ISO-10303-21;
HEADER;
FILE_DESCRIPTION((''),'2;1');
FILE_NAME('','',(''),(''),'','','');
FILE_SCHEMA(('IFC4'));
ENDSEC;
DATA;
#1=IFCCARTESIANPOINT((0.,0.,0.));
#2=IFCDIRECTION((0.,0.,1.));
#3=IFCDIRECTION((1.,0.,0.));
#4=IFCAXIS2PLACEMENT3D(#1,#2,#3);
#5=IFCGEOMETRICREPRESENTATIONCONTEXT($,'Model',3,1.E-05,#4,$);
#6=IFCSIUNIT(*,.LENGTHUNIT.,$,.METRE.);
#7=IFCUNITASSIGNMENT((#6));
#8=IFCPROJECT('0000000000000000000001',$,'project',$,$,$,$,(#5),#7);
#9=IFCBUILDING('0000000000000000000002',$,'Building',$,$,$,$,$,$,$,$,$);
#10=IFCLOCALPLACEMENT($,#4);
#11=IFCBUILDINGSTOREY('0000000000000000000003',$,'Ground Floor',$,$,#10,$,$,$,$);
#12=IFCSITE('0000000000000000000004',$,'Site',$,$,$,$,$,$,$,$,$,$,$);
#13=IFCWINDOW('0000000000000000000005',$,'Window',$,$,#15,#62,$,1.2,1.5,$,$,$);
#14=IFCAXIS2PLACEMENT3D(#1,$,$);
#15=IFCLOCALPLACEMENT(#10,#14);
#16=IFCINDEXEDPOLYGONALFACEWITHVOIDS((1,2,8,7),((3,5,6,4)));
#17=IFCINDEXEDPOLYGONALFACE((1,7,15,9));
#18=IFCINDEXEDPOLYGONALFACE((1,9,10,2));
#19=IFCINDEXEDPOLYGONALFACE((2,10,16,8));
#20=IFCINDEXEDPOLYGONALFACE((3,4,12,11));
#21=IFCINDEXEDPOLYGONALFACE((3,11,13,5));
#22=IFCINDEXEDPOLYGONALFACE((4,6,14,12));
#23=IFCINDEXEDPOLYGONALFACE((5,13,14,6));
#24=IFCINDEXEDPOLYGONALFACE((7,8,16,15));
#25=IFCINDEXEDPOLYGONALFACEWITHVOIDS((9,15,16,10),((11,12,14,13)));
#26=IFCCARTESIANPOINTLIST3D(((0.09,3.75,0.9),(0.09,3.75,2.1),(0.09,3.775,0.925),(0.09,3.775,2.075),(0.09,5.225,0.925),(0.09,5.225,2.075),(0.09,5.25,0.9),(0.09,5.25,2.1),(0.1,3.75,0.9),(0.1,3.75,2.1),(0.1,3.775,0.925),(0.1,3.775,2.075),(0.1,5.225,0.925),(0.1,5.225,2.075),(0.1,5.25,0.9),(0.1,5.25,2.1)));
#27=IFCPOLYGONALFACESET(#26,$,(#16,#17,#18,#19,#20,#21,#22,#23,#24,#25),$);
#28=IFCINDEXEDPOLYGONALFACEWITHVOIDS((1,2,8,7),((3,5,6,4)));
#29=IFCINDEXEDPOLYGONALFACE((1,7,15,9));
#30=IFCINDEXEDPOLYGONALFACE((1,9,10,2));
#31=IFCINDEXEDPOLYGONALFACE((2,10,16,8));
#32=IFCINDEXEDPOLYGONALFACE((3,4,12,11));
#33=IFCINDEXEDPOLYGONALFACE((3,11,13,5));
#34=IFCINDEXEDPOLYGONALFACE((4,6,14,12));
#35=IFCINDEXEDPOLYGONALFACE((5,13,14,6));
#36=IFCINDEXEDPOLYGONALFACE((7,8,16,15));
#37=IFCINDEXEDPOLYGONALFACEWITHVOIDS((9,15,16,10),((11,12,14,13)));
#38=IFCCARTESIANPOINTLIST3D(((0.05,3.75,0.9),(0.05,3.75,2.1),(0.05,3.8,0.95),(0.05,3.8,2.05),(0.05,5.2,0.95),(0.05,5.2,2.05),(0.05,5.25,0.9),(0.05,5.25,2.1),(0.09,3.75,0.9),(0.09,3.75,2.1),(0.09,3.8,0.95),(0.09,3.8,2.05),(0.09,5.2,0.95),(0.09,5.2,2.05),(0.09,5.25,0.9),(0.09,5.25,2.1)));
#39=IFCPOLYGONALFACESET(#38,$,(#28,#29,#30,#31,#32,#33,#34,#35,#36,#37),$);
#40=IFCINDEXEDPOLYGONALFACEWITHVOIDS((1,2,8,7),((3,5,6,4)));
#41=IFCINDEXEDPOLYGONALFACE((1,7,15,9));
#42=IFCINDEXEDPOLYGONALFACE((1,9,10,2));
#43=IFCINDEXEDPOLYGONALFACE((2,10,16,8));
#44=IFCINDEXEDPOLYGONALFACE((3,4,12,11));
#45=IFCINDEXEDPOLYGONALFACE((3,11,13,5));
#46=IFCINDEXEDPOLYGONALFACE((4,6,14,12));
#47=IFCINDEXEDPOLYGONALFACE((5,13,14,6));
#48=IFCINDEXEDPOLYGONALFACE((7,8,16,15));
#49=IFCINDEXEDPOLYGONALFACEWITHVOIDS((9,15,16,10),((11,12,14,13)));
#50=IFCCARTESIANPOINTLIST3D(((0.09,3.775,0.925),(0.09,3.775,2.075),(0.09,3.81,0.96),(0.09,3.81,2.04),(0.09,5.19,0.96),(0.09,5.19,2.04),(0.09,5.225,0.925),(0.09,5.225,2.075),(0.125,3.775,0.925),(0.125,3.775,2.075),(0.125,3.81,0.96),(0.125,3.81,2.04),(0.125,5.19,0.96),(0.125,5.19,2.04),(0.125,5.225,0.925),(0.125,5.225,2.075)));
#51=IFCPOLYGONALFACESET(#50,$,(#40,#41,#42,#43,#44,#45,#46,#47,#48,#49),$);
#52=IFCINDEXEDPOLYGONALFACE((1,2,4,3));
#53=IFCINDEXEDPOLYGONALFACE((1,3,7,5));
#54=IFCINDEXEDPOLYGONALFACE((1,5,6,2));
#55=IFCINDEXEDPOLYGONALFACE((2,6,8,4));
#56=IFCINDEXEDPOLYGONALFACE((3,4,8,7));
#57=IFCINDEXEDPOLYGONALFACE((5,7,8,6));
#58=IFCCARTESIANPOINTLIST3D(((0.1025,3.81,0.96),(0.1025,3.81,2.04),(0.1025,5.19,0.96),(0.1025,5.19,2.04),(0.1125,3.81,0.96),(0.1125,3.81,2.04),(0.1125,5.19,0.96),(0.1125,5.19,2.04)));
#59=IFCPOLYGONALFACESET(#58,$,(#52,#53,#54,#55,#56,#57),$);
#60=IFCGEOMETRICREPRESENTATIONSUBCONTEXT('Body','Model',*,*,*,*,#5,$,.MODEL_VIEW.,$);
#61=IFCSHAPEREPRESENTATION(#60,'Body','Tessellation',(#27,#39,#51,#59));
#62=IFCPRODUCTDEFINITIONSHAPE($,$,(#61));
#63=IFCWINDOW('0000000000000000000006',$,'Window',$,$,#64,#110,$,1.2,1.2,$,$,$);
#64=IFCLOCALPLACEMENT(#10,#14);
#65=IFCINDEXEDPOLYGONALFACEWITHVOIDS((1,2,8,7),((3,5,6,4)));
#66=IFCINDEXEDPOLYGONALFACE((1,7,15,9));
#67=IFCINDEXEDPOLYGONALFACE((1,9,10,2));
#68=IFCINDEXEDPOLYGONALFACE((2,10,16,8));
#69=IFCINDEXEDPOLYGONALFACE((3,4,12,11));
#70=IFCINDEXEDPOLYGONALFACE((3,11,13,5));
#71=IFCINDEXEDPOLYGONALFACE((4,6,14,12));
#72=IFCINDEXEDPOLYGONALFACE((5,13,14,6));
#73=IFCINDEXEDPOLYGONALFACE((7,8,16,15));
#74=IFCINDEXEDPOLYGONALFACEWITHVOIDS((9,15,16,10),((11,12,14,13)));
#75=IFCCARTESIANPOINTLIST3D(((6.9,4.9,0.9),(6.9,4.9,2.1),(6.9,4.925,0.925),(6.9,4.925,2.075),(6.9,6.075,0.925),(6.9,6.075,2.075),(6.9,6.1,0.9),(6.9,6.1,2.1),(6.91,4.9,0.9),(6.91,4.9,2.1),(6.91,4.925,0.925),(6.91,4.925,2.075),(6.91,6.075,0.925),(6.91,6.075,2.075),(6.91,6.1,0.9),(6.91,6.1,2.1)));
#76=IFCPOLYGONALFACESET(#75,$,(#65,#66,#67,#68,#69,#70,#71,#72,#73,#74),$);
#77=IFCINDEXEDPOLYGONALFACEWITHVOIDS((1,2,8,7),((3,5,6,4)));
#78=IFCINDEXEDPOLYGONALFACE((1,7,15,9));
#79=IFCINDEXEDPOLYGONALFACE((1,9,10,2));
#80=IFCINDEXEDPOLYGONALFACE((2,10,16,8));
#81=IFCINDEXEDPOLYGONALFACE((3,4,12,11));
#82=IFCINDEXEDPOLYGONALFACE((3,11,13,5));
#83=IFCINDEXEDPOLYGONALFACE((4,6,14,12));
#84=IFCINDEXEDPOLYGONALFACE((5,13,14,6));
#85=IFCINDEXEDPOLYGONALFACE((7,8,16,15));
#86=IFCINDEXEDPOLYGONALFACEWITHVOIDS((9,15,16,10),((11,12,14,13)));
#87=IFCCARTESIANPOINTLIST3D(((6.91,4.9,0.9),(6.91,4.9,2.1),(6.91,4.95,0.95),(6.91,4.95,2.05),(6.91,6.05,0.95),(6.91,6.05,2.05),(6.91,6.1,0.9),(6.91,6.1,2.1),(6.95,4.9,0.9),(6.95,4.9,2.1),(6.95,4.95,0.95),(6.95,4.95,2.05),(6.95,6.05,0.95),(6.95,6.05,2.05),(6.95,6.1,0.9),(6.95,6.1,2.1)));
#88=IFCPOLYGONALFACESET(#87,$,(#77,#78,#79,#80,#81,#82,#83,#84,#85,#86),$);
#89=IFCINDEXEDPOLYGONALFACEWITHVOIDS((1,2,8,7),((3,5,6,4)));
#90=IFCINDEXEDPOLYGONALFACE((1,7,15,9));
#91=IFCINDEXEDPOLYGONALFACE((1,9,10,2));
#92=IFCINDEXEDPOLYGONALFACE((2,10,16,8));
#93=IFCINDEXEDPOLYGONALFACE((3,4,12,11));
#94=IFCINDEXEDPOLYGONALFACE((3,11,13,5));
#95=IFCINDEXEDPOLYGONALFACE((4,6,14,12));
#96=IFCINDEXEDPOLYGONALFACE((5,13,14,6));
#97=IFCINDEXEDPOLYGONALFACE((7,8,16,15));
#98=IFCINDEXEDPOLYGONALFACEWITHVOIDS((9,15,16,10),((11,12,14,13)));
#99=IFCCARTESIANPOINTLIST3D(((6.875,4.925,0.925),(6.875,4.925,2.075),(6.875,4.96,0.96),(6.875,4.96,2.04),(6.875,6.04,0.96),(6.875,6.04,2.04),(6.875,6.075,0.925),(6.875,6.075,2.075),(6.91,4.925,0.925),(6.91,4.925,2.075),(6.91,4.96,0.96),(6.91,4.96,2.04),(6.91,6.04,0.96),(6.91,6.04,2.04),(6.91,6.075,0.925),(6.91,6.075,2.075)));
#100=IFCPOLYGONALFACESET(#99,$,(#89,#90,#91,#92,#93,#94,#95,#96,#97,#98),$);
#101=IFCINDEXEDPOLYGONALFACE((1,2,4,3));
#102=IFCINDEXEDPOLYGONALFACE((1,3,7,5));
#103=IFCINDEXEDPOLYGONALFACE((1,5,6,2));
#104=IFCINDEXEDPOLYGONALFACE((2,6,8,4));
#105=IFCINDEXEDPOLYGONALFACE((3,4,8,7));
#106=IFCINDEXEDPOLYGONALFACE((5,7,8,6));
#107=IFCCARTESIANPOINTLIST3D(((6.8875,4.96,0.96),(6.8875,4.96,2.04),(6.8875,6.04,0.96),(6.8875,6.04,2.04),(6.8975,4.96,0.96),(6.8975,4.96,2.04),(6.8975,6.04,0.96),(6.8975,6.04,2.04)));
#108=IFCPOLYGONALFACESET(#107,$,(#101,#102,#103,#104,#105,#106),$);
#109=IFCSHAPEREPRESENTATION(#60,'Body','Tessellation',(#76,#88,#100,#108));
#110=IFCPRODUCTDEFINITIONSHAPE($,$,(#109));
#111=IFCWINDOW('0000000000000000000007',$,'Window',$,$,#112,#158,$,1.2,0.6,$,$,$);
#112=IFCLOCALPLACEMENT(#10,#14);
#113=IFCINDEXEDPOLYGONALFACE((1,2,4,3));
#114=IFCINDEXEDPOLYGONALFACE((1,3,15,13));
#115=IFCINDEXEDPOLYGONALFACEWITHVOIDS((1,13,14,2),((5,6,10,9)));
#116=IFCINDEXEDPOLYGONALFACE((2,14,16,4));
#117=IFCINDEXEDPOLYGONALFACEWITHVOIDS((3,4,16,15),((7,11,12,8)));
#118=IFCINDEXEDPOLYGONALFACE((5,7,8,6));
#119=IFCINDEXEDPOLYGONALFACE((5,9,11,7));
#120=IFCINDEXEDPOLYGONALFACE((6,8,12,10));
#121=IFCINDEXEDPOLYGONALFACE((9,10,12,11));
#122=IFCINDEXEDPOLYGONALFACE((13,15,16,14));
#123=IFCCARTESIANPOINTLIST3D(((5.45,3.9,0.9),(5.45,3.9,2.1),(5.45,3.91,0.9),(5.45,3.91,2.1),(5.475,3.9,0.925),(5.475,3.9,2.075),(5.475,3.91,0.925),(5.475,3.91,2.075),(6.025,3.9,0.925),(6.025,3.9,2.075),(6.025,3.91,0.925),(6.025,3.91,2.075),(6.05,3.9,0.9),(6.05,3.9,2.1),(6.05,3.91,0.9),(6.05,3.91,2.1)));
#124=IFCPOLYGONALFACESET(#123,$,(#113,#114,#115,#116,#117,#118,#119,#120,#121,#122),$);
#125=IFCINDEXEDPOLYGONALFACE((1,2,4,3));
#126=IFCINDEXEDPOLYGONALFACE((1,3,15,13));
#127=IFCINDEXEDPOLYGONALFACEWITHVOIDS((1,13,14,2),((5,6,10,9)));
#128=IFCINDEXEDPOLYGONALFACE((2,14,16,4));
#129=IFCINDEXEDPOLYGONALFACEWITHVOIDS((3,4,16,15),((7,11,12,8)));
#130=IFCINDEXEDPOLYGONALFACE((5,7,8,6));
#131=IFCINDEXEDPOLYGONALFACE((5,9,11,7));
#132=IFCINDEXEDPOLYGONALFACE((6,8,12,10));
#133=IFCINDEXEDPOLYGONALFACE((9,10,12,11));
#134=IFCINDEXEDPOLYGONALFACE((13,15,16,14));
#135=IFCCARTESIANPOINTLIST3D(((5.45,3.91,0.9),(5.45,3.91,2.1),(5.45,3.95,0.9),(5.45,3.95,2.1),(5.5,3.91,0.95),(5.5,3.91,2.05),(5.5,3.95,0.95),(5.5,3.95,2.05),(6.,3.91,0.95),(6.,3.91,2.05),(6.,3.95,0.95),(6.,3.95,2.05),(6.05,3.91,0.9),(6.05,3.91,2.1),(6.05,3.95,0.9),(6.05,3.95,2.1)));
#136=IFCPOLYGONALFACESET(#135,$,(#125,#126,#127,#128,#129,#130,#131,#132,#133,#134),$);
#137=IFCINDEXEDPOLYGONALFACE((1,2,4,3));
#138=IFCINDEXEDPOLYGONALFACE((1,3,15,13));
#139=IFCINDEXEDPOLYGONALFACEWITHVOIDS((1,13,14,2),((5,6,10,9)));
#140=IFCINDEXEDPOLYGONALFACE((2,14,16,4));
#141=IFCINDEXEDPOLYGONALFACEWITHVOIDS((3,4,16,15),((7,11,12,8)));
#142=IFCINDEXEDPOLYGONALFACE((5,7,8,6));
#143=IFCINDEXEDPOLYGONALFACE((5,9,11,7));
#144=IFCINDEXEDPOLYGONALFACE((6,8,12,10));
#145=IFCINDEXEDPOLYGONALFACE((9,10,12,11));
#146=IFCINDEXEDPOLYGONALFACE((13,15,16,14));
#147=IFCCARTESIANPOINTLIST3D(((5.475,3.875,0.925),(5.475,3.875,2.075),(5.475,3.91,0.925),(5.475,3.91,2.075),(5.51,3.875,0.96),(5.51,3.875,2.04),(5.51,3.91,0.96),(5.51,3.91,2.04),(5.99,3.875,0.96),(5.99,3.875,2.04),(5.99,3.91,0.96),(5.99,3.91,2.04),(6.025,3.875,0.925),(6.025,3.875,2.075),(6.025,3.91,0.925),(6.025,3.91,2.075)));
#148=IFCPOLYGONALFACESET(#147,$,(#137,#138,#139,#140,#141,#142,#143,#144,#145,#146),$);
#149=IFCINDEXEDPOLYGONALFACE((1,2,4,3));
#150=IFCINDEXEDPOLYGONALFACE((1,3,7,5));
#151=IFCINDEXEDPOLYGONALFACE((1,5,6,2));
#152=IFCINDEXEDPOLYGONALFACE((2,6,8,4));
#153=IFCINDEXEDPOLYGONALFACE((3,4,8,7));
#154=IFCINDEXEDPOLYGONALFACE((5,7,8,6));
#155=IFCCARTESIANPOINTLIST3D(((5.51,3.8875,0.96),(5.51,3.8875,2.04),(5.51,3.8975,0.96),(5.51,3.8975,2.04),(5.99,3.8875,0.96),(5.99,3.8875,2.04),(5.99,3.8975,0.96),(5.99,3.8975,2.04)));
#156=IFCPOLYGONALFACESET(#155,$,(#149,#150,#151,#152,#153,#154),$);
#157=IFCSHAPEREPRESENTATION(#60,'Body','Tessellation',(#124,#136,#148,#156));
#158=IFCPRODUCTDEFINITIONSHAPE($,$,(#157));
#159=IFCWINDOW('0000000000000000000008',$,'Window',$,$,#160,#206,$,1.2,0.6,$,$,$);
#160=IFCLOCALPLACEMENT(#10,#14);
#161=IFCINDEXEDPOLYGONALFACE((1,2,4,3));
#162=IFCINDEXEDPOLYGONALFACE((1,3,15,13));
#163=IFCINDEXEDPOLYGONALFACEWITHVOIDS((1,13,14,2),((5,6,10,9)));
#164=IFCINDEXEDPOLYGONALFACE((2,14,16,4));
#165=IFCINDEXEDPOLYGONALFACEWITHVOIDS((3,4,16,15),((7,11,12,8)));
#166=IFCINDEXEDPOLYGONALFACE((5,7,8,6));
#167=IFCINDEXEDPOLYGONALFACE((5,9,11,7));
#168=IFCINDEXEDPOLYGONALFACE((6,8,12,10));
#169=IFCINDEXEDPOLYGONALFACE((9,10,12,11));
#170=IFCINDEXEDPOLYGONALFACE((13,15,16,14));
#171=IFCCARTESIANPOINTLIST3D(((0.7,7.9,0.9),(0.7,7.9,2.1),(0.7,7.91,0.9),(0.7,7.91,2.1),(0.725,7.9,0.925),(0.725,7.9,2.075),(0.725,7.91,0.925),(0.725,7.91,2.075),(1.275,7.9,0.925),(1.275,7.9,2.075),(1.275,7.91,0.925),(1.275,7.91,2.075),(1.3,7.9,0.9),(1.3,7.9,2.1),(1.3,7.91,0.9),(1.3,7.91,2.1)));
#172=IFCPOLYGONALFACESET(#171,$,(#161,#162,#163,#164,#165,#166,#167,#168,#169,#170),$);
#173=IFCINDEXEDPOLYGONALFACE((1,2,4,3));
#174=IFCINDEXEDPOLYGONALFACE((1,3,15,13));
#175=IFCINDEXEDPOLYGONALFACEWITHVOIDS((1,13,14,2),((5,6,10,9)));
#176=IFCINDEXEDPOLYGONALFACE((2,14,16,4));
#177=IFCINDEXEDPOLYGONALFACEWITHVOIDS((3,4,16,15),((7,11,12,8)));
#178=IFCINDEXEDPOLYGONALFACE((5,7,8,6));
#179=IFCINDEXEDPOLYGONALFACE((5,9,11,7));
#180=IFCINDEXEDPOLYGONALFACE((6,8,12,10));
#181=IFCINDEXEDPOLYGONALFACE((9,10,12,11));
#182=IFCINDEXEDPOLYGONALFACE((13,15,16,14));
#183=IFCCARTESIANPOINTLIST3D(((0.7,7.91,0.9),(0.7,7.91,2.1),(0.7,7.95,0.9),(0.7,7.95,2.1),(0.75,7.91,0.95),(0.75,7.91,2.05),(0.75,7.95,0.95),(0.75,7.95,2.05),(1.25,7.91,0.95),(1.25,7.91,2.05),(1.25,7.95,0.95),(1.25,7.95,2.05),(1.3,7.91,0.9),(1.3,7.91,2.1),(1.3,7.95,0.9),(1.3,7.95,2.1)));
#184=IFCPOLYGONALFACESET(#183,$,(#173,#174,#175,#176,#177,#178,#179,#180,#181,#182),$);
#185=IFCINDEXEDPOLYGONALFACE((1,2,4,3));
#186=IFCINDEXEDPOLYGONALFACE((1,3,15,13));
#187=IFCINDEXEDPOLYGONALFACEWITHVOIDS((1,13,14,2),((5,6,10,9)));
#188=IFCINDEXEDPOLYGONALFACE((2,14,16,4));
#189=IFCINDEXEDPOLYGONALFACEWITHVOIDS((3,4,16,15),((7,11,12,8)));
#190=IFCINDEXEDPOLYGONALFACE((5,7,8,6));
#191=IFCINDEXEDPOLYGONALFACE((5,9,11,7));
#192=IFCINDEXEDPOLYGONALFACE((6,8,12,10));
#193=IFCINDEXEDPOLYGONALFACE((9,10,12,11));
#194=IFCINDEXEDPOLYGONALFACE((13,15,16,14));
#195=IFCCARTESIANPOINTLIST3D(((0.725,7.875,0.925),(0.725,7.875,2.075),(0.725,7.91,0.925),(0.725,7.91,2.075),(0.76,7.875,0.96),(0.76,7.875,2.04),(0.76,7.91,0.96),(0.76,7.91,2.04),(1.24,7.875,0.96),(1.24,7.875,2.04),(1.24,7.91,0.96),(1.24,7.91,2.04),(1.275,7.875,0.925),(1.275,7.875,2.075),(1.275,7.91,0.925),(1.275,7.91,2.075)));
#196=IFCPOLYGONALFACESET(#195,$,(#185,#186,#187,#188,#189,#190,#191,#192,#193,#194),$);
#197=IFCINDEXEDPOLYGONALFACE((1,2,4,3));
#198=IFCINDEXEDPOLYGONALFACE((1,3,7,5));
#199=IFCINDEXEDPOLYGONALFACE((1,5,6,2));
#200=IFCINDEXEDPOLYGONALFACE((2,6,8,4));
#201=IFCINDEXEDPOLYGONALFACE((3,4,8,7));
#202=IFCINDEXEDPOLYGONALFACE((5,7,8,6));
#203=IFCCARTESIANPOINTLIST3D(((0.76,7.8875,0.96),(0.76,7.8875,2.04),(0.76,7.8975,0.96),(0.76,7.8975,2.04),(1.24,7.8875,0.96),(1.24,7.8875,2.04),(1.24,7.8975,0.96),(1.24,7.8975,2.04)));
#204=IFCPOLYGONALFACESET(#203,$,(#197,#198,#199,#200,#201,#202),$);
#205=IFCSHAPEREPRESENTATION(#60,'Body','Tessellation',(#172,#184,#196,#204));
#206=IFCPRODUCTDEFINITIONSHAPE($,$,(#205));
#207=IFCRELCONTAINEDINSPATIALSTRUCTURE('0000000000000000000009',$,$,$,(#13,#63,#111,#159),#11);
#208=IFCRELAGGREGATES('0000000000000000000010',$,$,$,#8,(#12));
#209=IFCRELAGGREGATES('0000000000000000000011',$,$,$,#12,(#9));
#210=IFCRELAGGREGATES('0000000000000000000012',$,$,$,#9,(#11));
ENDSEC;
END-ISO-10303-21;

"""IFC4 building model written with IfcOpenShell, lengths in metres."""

from ifc_helpers import new_model, si_unit, frame, origin_with_axes, place, context, subcontext, project, spatial, line, indexed_curve, outline, extrude, element, save


model = new_model("IFC4")

# Units and contexts
model_context = context("Model", 3, precision=1e-05, world=origin_with_axes())
body_context = subcontext(model_context, "Body", "Model", "MODEL_VIEW")
ifc_project = project(units=[si_unit("LENGTHUNIT", "METRE")], contexts=[model_context])

# Site, building, storey
site = spatial("IfcSite", under=ifc_project, Name="Site")
building = spatial("IfcBuilding", under=site, Name="Building")
storey_placement = place(None, origin_with_axes())
storey = spatial("IfcBuildingStorey", under=building, at=storey_placement, Name="Ground Floor")

# Windows
window_1_placement = place(storey_placement, frame((0.0, 5.25, 0.9), z_axis=(0.0, 0.0, 1.0), x_axis=(0.0, -1.0, 0.0)))
element("IfcWindow", 1, at=window_1_placement, inside=storey, Name="Window", OverallHeight=1.2, OverallWidth=1.5, context=body_context, shape_type="SweptSolid", body=[
    extrude(outline(indexed_curve([(0.0, 0.0), (1.5, 0.0), (1.5, 1.2), (0.0, 1.2)], segments=[line(1, 2, 3, 4, 1)]), holes=[indexed_curve([(0.025, 0.025), (1.475, 0.025), (1.475, 1.175), (0.025, 1.175)], segments=[line(1, 2, 3, 4, 1)])]), frame((0.0, 0.09, 0.0), z_axis=(0.0, -1.0, 0.0), x_axis=(1.0, 0.0, 0.0)), (0.0, 0.0, -1.0), 0.01),
    extrude(outline(indexed_curve([(0.0, 0.0), (1.5, 0.0), (1.5, 1.2), (0.0, 1.2)], segments=[line(1, 2, 3, 4, 1)]), holes=[indexed_curve([(0.05, 0.05), (1.45, 0.05), (1.45, 1.15), (0.05, 1.15)], segments=[line(1, 2, 3, 4, 1)])]), frame((0.0, 0.05, 0.0), z_axis=(0.0, -1.0, 0.0), x_axis=(1.0, 0.0, 0.0)), (0.0, 0.0, -1.0), 0.04),
    extrude(outline(indexed_curve([(0.0, 0.0), (1.45, 0.0), (1.45, 1.15), (0.0, 1.15)], segments=[line(1, 2, 3, 4, 1)]), holes=[indexed_curve([(0.035, 0.035), (1.415, 0.035), (1.415, 1.115), (0.035, 1.115)], segments=[line(1, 2, 3, 4, 1)])]), frame((0.025, 0.09, 0.025), z_axis=(0.0, -1.0, 0.0), x_axis=(1.0, 0.0, 0.0)), (0.0, 0.0, -1.0), 0.035),
    extrude(outline(indexed_curve([(0.035, 0.035), (1.415, 0.035), (1.415, 1.115), (0.035, 1.115)], segments=[line(1, 2, 3, 4, 1)])), frame((0.025, 0.1025, 0.025), z_axis=(0.0, -1.0, 0.0), x_axis=(1.0, 0.0, 0.0)), (0.0, 0.0, -1.0), 0.01),
])
window_2_placement = place(storey_placement, frame((7.0, 4.9, 0.9), z_axis=(0.0, 0.0, 1.0), x_axis=(0.0, 1.0, 0.0)))
element("IfcWindow", 2, at=window_2_placement, inside=storey, Name="Window", OverallHeight=1.2, OverallWidth=1.2, context=body_context, shape_type="SweptSolid", body=[
    extrude(outline(indexed_curve([(0.0, 0.0), (1.2, 0.0), (1.2, 1.2), (0.0, 1.2)], segments=[line(1, 2, 3, 4, 1)]), holes=[indexed_curve([(0.025, 0.025), (1.175, 0.025), (1.175, 1.175), (0.025, 1.175)], segments=[line(1, 2, 3, 4, 1)])]), frame((0.0, 0.09, 0.0), z_axis=(0.0, -1.0, 0.0), x_axis=(1.0, 0.0, 0.0)), (0.0, 0.0, -1.0), 0.01),
    extrude(outline(indexed_curve([(0.0, 0.0), (1.2, 0.0), (1.2, 1.2), (0.0, 1.2)], segments=[line(1, 2, 3, 4, 1)]), holes=[indexed_curve([(0.05, 0.05), (1.15, 0.05), (1.15, 1.15), (0.05, 1.15)], segments=[line(1, 2, 3, 4, 1)])]), frame((0.0, 0.05, 0.0), z_axis=(0.0, -1.0, 0.0), x_axis=(1.0, 0.0, 0.0)), (0.0, 0.0, -1.0), 0.04),
    extrude(outline(indexed_curve([(0.0, 0.0), (1.15, 0.0), (1.15, 1.15), (0.0, 1.15)], segments=[line(1, 2, 3, 4, 1)]), holes=[indexed_curve([(0.035, 0.035), (1.115, 0.035), (1.115, 1.115), (0.035, 1.115)], segments=[line(1, 2, 3, 4, 1)])]), frame((0.025, 0.09, 0.025), z_axis=(0.0, -1.0, 0.0), x_axis=(1.0, 0.0, 0.0)), (0.0, 0.0, -1.0), 0.035),
    extrude(outline(indexed_curve([(0.035, 0.035), (1.115, 0.035), (1.115, 1.115), (0.035, 1.115)], segments=[line(1, 2, 3, 4, 1)])), frame((0.025, 0.1025, 0.025), z_axis=(0.0, -1.0, 0.0), x_axis=(1.0, 0.0, 0.0)), (0.0, 0.0, -1.0), 0.01),
])
for number, where, z_axis, x_axis, name in (
    (3, (6.05, 4.0, 0.9), (0.0, 0.0, 1.0), (-1.0, 0.0, 0.0), "Window"),
    (4, (1.3, 8.0, 0.9), (0.0, 0.0, 1.0), (-1.0, 0.0, 0.0), "Window"),
):
    element("IfcWindow", number, at=place(storey_placement, frame(where, z_axis=z_axis, x_axis=x_axis)), inside=storey, Name=name, OverallHeight=1.2, OverallWidth=0.6, context=body_context, shape_type="SweptSolid", body=[
        extrude(outline(indexed_curve([(0.0, 0.0), (0.6, 0.0), (0.6, 1.2), (0.0, 1.2)], segments=[line(1, 2, 3, 4, 1)]), holes=[indexed_curve([(0.025, 0.025), (0.575, 0.025), (0.575, 1.175), (0.025, 1.175)], segments=[line(1, 2, 3, 4, 1)])]), frame((0.0, 0.09, 0.0), z_axis=(0.0, -1.0, 0.0), x_axis=(1.0, 0.0, 0.0)), (0.0, 0.0, -1.0), 0.01),
        extrude(outline(indexed_curve([(0.0, 0.0), (0.6, 0.0), (0.6, 1.2), (0.0, 1.2)], segments=[line(1, 2, 3, 4, 1)]), holes=[indexed_curve([(0.05, 0.05), (0.55, 0.05), (0.55, 1.15), (0.05, 1.15)], segments=[line(1, 2, 3, 4, 1)])]), frame((0.0, 0.05, 0.0), z_axis=(0.0, -1.0, 0.0), x_axis=(1.0, 0.0, 0.0)), (0.0, 0.0, -1.0), 0.04),
        extrude(outline(indexed_curve([(0.0, 0.0), (0.55, 0.0), (0.55, 1.15), (0.0, 1.15)], segments=[line(1, 2, 3, 4, 1)]), holes=[indexed_curve([(0.035, 0.035), (0.515, 0.035), (0.515, 1.115), (0.035, 1.115)], segments=[line(1, 2, 3, 4, 1)])]), frame((0.025, 0.09, 0.025), z_axis=(0.0, -1.0, 0.0), x_axis=(1.0, 0.0, 0.0)), (0.0, 0.0, -1.0), 0.035),
        extrude(outline(indexed_curve([(0.035, 0.035), (0.515, 0.035), (0.515, 1.115), (0.035, 1.115)], segments=[line(1, 2, 3, 4, 1)])), frame((0.025, 0.1025, 0.025), z_axis=(0.0, -1.0, 0.0), x_axis=(1.0, 0.0, 0.0)), (0.0, 0.0, -1.0), 0.01),
    ])

save(model, "model.ifc")
